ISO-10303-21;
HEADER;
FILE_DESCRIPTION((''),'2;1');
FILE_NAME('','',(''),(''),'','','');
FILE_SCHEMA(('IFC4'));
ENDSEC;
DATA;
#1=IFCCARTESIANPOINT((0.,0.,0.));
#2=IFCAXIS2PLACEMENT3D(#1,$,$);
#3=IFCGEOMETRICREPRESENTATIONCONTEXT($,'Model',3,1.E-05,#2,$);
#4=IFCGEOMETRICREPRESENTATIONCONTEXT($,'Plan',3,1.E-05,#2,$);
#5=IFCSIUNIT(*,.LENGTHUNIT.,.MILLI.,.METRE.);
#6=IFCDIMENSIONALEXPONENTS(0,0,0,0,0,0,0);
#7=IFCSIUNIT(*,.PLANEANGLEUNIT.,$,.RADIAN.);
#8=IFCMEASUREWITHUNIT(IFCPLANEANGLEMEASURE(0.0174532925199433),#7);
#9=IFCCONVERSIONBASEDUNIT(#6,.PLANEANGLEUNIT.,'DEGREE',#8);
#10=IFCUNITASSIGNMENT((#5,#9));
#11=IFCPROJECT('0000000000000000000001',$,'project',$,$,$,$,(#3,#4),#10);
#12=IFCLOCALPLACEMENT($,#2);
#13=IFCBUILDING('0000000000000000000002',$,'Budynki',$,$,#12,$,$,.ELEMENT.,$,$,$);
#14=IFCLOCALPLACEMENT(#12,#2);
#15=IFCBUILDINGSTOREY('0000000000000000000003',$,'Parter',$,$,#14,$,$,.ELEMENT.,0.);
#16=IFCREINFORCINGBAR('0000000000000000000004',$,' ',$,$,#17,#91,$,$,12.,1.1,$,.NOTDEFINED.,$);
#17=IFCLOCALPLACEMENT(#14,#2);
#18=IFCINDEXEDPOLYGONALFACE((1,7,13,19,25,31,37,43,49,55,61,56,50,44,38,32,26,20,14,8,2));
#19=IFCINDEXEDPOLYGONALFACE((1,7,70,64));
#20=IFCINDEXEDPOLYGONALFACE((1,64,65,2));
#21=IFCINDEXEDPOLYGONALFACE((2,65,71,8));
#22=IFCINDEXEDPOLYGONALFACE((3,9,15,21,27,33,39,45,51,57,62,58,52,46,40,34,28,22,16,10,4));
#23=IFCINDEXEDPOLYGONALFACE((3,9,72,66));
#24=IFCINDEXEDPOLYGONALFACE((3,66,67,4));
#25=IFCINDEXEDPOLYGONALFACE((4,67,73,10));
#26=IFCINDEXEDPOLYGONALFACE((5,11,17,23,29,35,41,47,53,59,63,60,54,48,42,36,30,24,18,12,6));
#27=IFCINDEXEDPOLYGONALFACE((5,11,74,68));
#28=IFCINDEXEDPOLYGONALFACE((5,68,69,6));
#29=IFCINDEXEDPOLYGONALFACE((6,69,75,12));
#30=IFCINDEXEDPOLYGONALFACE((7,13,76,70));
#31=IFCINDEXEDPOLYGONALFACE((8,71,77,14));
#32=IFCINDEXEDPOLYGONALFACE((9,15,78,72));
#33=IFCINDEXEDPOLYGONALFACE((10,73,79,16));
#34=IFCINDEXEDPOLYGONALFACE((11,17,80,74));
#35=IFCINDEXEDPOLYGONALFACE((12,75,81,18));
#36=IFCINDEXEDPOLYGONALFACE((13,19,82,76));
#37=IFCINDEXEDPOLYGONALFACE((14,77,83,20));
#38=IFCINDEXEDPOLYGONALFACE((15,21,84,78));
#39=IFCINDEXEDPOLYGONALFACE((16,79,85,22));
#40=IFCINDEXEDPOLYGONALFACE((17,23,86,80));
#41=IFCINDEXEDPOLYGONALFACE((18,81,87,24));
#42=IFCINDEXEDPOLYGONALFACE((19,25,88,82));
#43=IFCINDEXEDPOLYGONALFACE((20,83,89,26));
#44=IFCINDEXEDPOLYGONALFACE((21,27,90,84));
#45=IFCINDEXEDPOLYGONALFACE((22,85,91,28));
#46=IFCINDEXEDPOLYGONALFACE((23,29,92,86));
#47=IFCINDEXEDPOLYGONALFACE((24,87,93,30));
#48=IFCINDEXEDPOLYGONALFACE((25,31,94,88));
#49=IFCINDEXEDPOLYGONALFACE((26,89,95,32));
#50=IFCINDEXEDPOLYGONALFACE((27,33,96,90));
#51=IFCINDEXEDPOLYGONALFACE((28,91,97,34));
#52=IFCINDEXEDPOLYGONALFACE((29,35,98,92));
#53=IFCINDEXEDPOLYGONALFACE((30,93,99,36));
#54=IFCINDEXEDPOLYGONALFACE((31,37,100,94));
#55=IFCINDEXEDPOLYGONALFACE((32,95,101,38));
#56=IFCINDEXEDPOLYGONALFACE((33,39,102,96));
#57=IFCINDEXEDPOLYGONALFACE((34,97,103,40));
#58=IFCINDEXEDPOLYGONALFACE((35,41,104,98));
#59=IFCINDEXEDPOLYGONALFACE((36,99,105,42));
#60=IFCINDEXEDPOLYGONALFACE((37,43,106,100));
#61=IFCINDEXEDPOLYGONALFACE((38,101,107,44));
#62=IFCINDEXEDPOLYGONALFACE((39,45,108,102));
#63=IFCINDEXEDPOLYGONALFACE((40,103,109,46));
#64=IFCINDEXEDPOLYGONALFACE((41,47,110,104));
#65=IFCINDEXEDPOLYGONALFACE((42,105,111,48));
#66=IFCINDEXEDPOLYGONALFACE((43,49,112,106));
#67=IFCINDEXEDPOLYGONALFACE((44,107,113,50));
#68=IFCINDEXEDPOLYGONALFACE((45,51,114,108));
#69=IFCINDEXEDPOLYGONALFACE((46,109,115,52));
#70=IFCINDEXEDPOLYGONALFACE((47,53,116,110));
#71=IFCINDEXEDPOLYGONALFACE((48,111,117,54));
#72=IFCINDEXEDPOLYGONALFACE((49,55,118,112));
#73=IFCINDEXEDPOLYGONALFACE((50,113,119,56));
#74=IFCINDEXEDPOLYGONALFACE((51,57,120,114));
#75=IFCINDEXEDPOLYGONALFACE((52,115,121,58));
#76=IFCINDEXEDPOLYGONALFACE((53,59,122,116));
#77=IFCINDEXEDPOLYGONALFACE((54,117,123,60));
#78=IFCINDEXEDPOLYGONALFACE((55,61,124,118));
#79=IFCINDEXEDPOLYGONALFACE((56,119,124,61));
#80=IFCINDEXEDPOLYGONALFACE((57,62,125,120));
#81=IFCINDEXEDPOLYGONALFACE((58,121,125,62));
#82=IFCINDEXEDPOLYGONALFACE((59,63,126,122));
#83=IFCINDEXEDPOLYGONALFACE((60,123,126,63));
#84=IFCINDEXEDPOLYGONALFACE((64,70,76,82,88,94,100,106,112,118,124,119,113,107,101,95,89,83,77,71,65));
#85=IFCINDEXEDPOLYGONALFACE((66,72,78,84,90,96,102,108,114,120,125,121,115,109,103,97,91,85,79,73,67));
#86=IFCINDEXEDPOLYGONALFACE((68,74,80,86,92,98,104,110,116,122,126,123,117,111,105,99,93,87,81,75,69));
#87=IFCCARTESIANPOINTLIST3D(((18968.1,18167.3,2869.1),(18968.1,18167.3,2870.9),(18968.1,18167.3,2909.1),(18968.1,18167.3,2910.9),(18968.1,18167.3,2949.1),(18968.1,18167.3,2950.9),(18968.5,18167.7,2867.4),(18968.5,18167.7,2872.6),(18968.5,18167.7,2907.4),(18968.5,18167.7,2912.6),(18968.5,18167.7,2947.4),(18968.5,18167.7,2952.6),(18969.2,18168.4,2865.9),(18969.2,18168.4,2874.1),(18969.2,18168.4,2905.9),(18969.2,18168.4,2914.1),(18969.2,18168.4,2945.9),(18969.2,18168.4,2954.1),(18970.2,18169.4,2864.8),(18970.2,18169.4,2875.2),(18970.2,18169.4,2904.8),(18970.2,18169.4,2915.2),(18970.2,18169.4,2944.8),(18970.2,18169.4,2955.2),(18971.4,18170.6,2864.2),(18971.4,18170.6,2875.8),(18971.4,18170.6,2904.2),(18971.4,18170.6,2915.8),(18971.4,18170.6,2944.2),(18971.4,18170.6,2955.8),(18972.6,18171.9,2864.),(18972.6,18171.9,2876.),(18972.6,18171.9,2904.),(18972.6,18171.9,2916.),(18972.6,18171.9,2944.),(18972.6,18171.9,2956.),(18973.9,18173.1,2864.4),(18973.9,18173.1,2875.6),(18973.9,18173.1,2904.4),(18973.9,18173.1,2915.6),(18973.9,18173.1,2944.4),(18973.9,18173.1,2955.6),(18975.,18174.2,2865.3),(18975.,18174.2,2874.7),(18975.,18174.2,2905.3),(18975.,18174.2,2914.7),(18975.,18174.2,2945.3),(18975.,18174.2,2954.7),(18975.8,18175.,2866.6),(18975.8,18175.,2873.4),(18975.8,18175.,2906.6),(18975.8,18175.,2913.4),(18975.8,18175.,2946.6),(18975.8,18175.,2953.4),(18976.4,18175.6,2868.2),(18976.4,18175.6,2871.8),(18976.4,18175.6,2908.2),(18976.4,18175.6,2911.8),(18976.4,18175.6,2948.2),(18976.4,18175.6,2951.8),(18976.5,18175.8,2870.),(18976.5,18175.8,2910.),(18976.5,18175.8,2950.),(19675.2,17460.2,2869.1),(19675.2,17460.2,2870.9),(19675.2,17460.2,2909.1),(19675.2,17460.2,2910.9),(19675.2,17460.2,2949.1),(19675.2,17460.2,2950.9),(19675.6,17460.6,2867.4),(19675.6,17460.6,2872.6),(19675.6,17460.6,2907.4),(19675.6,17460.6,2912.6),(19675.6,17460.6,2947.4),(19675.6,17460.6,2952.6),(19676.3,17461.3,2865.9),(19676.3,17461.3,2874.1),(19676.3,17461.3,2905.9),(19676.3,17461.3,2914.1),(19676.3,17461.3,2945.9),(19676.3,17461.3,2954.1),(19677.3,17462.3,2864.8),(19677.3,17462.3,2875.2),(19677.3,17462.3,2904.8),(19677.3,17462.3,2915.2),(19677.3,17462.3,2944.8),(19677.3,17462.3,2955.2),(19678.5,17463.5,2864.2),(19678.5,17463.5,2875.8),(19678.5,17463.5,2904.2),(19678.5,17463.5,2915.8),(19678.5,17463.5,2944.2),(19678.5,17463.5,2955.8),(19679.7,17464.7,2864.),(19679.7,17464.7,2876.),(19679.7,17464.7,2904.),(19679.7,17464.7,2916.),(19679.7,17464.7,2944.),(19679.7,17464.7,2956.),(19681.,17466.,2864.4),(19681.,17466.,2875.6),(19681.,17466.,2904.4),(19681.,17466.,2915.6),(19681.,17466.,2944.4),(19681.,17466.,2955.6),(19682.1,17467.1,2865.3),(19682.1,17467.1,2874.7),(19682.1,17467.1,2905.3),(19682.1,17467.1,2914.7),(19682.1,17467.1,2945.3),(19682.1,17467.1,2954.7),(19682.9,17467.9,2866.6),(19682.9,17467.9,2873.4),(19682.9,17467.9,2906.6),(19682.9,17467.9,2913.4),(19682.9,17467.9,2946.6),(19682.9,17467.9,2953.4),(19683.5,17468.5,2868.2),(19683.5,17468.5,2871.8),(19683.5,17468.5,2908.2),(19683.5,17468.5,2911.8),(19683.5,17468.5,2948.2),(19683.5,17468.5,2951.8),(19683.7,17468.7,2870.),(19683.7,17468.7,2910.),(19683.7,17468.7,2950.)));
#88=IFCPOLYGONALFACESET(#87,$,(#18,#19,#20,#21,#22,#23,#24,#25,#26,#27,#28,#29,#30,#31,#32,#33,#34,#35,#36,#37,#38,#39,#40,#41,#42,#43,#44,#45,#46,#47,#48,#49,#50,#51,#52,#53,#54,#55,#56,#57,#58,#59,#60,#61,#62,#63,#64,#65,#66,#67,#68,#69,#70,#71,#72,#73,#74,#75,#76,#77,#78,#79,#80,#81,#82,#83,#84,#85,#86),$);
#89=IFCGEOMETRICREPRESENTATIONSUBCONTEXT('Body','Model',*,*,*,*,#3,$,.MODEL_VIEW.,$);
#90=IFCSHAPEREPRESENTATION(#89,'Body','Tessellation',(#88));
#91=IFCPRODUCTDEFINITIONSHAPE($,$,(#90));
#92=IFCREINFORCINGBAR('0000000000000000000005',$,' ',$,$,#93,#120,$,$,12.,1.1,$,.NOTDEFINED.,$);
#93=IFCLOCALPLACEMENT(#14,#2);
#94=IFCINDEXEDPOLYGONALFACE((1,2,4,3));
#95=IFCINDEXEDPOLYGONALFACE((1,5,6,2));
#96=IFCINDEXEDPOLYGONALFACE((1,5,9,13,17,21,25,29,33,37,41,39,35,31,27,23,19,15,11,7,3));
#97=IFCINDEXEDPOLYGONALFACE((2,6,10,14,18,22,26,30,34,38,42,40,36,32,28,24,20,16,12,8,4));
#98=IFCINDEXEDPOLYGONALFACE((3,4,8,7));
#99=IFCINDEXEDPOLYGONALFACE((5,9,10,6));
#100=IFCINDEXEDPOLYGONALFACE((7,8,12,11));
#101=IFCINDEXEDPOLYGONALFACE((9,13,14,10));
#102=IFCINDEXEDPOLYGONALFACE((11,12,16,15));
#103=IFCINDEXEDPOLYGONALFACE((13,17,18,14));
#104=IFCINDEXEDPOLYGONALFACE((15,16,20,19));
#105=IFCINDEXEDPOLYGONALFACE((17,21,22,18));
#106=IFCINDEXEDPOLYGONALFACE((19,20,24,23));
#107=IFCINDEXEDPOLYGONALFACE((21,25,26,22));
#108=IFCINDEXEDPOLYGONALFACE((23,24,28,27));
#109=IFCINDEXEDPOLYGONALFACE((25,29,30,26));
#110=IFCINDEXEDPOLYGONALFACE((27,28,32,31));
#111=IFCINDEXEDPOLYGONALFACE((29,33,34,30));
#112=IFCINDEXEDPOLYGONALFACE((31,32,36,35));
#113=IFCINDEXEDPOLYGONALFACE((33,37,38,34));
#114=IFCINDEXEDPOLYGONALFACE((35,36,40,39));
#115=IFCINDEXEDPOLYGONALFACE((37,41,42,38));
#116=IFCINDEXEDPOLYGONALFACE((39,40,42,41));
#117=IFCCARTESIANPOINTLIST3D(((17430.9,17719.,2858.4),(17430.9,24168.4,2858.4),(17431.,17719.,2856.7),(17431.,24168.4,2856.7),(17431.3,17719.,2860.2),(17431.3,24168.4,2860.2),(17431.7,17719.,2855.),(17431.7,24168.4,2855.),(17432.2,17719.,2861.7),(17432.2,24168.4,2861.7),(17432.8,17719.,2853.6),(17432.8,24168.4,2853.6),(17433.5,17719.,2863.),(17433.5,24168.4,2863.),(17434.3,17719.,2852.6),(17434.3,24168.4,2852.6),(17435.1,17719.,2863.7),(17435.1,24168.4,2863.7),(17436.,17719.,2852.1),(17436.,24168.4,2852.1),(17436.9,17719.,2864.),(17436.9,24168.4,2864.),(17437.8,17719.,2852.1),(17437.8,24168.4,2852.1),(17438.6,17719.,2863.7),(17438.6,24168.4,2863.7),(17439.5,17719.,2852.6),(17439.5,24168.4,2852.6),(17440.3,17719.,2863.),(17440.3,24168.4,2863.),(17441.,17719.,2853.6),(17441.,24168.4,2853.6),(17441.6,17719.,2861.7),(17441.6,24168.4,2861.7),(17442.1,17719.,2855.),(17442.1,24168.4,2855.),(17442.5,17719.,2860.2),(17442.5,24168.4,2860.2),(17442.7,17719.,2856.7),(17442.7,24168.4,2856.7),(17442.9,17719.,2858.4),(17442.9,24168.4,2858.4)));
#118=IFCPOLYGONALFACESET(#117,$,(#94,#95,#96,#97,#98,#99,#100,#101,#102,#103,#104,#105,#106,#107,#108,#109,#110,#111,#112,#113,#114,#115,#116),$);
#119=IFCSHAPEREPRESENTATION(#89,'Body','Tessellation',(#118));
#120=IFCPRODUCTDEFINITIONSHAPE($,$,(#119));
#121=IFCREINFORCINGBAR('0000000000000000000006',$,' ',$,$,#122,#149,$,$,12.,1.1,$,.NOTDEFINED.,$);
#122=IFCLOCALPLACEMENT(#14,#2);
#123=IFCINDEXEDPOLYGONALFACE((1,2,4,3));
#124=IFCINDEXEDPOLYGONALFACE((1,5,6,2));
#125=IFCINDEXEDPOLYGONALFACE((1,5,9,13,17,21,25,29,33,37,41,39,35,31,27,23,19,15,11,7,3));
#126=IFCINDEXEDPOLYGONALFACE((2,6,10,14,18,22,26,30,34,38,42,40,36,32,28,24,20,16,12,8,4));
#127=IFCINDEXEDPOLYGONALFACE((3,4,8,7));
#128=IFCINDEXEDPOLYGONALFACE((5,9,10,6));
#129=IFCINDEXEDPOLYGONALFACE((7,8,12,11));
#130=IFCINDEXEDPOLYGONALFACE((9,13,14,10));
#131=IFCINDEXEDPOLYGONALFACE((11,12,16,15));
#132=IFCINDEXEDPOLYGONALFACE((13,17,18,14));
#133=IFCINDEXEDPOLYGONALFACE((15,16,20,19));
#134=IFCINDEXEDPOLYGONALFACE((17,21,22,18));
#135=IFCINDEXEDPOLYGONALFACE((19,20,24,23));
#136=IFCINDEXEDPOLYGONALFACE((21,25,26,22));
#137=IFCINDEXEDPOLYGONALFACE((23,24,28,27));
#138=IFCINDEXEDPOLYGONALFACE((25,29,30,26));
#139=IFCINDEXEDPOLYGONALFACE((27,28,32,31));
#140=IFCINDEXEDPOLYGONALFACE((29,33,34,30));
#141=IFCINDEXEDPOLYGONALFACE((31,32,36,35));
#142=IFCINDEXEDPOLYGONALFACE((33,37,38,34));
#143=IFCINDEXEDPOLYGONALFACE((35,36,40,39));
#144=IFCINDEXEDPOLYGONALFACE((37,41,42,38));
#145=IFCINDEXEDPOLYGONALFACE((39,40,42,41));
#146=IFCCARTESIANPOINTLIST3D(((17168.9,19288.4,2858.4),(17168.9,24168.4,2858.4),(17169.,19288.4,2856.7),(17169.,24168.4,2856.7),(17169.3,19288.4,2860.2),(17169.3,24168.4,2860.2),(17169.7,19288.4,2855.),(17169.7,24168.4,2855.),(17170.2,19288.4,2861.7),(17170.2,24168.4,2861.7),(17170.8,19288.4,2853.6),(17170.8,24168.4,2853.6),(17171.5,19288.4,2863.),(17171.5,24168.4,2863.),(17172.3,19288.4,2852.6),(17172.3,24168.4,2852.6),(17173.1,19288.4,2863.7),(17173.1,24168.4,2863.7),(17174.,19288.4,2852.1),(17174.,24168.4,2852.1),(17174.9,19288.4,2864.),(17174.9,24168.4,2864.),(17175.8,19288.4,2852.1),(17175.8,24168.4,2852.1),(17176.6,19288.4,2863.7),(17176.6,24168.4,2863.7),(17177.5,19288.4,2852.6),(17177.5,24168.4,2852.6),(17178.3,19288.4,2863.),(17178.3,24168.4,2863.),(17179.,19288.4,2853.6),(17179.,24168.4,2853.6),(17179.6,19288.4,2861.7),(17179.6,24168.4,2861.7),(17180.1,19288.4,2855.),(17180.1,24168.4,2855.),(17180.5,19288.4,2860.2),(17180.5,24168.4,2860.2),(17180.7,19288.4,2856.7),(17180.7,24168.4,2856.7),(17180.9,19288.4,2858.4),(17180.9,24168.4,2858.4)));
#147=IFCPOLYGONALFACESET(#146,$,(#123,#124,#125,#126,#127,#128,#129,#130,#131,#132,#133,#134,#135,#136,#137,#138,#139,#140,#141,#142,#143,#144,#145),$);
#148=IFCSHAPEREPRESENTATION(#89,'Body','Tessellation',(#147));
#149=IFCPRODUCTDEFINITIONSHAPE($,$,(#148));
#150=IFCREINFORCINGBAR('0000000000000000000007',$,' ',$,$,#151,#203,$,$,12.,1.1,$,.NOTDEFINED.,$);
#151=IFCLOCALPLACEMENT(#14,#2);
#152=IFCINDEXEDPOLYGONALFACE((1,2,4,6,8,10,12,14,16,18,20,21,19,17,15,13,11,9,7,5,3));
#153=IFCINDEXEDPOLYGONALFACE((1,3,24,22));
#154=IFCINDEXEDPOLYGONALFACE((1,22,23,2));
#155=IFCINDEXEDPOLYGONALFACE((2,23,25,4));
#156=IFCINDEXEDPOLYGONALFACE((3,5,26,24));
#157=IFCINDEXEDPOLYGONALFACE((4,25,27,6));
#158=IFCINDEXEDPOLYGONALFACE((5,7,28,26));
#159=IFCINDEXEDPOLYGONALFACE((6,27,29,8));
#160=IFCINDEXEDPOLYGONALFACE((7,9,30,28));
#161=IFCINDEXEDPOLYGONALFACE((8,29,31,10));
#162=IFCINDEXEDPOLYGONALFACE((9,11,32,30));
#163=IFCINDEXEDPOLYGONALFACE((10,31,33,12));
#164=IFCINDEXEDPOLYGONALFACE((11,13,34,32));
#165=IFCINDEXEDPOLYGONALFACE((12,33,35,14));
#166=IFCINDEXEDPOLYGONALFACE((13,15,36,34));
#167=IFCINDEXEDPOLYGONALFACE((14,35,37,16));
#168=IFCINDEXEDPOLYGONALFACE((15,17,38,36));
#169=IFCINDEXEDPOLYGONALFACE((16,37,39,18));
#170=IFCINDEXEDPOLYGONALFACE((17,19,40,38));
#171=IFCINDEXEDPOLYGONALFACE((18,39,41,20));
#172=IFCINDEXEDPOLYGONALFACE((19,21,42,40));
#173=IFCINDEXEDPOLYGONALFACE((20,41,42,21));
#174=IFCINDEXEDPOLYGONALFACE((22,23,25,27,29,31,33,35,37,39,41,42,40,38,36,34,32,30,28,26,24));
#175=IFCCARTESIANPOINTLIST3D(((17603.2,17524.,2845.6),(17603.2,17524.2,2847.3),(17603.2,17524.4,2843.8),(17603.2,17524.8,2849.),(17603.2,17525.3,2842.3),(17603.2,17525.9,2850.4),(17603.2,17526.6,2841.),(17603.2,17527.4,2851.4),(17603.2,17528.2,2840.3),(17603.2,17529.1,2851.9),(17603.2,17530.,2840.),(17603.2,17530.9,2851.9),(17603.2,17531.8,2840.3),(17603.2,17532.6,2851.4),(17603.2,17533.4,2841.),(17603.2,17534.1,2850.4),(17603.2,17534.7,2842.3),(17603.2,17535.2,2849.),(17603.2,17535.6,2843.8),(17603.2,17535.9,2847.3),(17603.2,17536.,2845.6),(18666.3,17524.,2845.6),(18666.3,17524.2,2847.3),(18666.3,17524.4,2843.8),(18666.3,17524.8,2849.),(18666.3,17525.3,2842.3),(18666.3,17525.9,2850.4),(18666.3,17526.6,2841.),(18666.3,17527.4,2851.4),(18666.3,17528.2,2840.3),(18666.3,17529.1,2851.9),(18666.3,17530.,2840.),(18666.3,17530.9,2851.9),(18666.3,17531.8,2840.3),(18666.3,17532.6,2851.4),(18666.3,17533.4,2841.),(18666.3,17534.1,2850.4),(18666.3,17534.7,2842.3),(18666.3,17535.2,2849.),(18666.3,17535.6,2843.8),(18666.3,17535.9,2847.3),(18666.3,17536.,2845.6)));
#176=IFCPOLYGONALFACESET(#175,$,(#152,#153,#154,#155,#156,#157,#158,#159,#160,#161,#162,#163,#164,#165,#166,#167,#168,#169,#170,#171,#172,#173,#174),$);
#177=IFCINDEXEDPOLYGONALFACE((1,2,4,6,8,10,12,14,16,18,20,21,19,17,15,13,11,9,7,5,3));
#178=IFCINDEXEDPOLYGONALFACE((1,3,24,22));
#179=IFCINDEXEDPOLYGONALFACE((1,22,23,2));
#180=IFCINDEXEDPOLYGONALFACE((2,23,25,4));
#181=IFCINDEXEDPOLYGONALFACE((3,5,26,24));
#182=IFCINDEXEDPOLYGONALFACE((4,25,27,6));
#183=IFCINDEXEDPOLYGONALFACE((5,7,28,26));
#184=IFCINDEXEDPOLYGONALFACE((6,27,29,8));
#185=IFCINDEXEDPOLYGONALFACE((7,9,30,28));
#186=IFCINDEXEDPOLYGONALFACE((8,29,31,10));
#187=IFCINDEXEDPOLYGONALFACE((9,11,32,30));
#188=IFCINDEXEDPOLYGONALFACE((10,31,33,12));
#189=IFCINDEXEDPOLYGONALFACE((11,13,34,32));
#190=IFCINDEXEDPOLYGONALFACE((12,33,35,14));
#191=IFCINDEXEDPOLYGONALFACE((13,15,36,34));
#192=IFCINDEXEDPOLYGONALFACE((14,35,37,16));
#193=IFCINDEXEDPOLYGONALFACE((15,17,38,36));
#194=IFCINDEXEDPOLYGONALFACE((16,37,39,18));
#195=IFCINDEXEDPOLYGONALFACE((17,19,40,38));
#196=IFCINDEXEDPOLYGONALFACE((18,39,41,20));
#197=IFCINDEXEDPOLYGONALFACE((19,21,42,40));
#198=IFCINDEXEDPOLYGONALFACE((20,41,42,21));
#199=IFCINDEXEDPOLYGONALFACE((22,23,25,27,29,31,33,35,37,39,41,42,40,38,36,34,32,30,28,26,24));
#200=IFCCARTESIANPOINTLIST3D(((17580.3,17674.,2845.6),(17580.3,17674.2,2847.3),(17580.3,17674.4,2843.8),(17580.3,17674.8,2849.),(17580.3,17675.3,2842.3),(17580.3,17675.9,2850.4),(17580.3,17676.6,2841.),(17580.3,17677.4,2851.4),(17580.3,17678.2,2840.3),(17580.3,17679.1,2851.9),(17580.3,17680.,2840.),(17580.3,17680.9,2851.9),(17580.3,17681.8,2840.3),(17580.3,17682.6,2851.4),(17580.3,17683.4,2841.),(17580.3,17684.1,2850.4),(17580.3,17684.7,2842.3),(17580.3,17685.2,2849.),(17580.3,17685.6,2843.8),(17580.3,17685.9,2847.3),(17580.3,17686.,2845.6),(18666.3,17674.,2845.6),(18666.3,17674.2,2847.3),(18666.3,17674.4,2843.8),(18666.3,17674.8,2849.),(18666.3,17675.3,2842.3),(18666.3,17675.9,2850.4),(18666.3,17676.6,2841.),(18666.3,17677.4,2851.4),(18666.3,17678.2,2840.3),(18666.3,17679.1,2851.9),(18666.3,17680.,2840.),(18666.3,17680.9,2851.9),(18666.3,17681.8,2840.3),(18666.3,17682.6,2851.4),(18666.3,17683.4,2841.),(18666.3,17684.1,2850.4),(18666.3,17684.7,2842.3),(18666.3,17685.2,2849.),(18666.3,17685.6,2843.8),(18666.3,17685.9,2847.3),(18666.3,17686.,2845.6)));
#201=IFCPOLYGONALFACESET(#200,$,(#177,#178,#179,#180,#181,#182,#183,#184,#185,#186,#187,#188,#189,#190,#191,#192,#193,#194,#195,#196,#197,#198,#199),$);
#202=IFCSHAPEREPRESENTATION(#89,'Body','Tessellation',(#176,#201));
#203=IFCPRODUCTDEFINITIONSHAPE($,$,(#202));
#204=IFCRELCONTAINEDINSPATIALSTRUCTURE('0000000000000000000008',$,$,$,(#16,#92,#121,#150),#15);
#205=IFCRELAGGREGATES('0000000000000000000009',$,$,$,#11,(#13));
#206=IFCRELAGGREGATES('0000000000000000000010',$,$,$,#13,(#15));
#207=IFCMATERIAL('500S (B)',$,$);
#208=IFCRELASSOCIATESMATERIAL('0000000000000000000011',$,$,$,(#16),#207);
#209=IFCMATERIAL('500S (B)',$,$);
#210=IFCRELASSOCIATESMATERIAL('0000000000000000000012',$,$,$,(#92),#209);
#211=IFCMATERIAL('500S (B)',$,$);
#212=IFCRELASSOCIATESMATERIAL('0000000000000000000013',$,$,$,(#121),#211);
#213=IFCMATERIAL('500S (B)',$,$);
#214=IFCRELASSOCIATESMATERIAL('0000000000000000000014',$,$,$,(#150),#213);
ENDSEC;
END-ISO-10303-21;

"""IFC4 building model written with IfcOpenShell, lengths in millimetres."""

from ifc_helpers import new_model, entity, si_unit, converted_unit, frame, origin, origin_with_axes, place, context, subcontext, project, spatial, source, transform, mapped, material, element, save


model = new_model("IFC4")

# Units and contexts
model_context = context("Model", 3, precision=1e-05, world=origin())
plan_context = context("Plan", 3, precision=1e-05, world=origin())
body_context = subcontext(model_context, "Body", "Model", "MODEL_VIEW")
ifc_project = project(units=[si_unit("LENGTHUNIT", "METRE", prefix="MILLI"), converted_unit("PLANEANGLEUNIT", "DEGREE", entity("IfcPlaneAngleMeasure", 0.0174532925199433), si_unit("PLANEANGLEUNIT", "RADIAN"), dimensions=[0, 0, 0, 0, 0, 0, 0])], contexts=[model_context, plan_context])

# Building, storey
building_placement = place(None, origin())
building = spatial("IfcBuilding", under=ifc_project, at=building_placement, Name="Budynki", CompositionType="ELEMENT")
storey_placement = place(building_placement, origin())
storey = spatial("IfcBuildingStorey", under=building, at=storey_placement, Name="Parter", CompositionType="ELEMENT", Elevation=0.0)

# Reinforcing bars
ifc_material_1 = material(Name="500S (B)")
shared_shape_1 = source(origin_with_axes(), body_context, "Body", "AdvancedSweptSolid", [
    entity("IfcSweptDiskSolid", entity("IfcPolyline", [entity("IfcCartesianPoint", [0.0, 0.0, 0.0]), entity("IfcCartesianPoint", [707.1, -707.1, 0.0])]), 6.0, None, 0.0, 1.0),
])
reinforcing_bar_1_placement = place(storey_placement, frame((18972.3, 18171.5, 2870.0)))
element("IfcReinforcingBar", 1, at=reinforcing_bar_1_placement, inside=storey, material=ifc_material_1, Name=" ", CrossSectionArea=1.1, NominalDiameter=12.0, PredefinedType="NOTDEFINED", context=body_context, shape_type="MappedRepresentation", body=[
    mapped(shared_shape_1, transform((0.0, 0.0, 0.0), y_axis=(0.0, 1.0, 0.0), scale=1.0)),
    mapped(shared_shape_1, transform((0.0, 0.0, 40.0), y_axis=(0.0, 1.0, 0.0), scale=1.0)),
    mapped(shared_shape_1, transform((0.0, 0.0, 80.0), y_axis=(0.0, 1.0, 0.0), scale=1.0)),
])
ifc_material_2 = material(Name="500S (B)")
reinforcing_bar_2_placement = place(storey_placement, frame((17436.9, 17719.0, 2858.0)))
element("IfcReinforcingBar", 2, at=reinforcing_bar_2_placement, inside=storey, material=ifc_material_2, Name=" ", CrossSectionArea=1.1, NominalDiameter=12.0, PredefinedType="NOTDEFINED", context=body_context, shape_type="AdvancedSweptSolid", body=[
    entity("IfcSweptDiskSolid", entity("IfcPolyline", [entity("IfcCartesianPoint", [0.0, 0.0, 0.0]), entity("IfcCartesianPoint", [0.0, 6449.4, 0.0])]), 6.0, None, 0.0, 1.0),
])
ifc_material_3 = material(Name="500S (B)")
reinforcing_bar_3_placement = place(storey_placement, frame((17174.9, 19288.4, 2858.0)))
element("IfcReinforcingBar", 3, at=reinforcing_bar_3_placement, inside=storey, material=ifc_material_3, Name=" ", CrossSectionArea=1.1, NominalDiameter=12.0, PredefinedType="NOTDEFINED", context=body_context, shape_type="AdvancedSweptSolid", body=[
    entity("IfcSweptDiskSolid", entity("IfcPolyline", [entity("IfcCartesianPoint", [0.0, 0.0, 0.0]), entity("IfcCartesianPoint", [0.0, 4880.0, 0.0])]), 6.0, None, 0.0, 1.0),
])
ifc_material_4 = material(Name="500S (B)")
reinforcing_bar_4_placement = place(storey_placement, frame((18666.3, 17530.0, 2846.0)))
element("IfcReinforcingBar", 4, at=reinforcing_bar_4_placement, inside=storey, material=ifc_material_4, Name=" ", CrossSectionArea=1.1, NominalDiameter=12.0, PredefinedType="NOTDEFINED", context=body_context, shape_type="AdvancedSweptSolid", body=[
    entity("IfcSweptDiskSolid", entity("IfcPolyline", [entity("IfcCartesianPoint", [0.0, 0.0, 0.0]), entity("IfcCartesianPoint", [-1063.1, 0.0, 0.0])]), 6.0, None, 0.0, 1.0),
    entity("IfcSweptDiskSolid", entity("IfcPolyline", [entity("IfcCartesianPoint", [0.0, 150.0, 0.0]), entity("IfcCartesianPoint", [-1086.1, 150.0, 0.0])]), 6.0, None, 0.0, 1.0),
])

save(model, "model.ifc")
